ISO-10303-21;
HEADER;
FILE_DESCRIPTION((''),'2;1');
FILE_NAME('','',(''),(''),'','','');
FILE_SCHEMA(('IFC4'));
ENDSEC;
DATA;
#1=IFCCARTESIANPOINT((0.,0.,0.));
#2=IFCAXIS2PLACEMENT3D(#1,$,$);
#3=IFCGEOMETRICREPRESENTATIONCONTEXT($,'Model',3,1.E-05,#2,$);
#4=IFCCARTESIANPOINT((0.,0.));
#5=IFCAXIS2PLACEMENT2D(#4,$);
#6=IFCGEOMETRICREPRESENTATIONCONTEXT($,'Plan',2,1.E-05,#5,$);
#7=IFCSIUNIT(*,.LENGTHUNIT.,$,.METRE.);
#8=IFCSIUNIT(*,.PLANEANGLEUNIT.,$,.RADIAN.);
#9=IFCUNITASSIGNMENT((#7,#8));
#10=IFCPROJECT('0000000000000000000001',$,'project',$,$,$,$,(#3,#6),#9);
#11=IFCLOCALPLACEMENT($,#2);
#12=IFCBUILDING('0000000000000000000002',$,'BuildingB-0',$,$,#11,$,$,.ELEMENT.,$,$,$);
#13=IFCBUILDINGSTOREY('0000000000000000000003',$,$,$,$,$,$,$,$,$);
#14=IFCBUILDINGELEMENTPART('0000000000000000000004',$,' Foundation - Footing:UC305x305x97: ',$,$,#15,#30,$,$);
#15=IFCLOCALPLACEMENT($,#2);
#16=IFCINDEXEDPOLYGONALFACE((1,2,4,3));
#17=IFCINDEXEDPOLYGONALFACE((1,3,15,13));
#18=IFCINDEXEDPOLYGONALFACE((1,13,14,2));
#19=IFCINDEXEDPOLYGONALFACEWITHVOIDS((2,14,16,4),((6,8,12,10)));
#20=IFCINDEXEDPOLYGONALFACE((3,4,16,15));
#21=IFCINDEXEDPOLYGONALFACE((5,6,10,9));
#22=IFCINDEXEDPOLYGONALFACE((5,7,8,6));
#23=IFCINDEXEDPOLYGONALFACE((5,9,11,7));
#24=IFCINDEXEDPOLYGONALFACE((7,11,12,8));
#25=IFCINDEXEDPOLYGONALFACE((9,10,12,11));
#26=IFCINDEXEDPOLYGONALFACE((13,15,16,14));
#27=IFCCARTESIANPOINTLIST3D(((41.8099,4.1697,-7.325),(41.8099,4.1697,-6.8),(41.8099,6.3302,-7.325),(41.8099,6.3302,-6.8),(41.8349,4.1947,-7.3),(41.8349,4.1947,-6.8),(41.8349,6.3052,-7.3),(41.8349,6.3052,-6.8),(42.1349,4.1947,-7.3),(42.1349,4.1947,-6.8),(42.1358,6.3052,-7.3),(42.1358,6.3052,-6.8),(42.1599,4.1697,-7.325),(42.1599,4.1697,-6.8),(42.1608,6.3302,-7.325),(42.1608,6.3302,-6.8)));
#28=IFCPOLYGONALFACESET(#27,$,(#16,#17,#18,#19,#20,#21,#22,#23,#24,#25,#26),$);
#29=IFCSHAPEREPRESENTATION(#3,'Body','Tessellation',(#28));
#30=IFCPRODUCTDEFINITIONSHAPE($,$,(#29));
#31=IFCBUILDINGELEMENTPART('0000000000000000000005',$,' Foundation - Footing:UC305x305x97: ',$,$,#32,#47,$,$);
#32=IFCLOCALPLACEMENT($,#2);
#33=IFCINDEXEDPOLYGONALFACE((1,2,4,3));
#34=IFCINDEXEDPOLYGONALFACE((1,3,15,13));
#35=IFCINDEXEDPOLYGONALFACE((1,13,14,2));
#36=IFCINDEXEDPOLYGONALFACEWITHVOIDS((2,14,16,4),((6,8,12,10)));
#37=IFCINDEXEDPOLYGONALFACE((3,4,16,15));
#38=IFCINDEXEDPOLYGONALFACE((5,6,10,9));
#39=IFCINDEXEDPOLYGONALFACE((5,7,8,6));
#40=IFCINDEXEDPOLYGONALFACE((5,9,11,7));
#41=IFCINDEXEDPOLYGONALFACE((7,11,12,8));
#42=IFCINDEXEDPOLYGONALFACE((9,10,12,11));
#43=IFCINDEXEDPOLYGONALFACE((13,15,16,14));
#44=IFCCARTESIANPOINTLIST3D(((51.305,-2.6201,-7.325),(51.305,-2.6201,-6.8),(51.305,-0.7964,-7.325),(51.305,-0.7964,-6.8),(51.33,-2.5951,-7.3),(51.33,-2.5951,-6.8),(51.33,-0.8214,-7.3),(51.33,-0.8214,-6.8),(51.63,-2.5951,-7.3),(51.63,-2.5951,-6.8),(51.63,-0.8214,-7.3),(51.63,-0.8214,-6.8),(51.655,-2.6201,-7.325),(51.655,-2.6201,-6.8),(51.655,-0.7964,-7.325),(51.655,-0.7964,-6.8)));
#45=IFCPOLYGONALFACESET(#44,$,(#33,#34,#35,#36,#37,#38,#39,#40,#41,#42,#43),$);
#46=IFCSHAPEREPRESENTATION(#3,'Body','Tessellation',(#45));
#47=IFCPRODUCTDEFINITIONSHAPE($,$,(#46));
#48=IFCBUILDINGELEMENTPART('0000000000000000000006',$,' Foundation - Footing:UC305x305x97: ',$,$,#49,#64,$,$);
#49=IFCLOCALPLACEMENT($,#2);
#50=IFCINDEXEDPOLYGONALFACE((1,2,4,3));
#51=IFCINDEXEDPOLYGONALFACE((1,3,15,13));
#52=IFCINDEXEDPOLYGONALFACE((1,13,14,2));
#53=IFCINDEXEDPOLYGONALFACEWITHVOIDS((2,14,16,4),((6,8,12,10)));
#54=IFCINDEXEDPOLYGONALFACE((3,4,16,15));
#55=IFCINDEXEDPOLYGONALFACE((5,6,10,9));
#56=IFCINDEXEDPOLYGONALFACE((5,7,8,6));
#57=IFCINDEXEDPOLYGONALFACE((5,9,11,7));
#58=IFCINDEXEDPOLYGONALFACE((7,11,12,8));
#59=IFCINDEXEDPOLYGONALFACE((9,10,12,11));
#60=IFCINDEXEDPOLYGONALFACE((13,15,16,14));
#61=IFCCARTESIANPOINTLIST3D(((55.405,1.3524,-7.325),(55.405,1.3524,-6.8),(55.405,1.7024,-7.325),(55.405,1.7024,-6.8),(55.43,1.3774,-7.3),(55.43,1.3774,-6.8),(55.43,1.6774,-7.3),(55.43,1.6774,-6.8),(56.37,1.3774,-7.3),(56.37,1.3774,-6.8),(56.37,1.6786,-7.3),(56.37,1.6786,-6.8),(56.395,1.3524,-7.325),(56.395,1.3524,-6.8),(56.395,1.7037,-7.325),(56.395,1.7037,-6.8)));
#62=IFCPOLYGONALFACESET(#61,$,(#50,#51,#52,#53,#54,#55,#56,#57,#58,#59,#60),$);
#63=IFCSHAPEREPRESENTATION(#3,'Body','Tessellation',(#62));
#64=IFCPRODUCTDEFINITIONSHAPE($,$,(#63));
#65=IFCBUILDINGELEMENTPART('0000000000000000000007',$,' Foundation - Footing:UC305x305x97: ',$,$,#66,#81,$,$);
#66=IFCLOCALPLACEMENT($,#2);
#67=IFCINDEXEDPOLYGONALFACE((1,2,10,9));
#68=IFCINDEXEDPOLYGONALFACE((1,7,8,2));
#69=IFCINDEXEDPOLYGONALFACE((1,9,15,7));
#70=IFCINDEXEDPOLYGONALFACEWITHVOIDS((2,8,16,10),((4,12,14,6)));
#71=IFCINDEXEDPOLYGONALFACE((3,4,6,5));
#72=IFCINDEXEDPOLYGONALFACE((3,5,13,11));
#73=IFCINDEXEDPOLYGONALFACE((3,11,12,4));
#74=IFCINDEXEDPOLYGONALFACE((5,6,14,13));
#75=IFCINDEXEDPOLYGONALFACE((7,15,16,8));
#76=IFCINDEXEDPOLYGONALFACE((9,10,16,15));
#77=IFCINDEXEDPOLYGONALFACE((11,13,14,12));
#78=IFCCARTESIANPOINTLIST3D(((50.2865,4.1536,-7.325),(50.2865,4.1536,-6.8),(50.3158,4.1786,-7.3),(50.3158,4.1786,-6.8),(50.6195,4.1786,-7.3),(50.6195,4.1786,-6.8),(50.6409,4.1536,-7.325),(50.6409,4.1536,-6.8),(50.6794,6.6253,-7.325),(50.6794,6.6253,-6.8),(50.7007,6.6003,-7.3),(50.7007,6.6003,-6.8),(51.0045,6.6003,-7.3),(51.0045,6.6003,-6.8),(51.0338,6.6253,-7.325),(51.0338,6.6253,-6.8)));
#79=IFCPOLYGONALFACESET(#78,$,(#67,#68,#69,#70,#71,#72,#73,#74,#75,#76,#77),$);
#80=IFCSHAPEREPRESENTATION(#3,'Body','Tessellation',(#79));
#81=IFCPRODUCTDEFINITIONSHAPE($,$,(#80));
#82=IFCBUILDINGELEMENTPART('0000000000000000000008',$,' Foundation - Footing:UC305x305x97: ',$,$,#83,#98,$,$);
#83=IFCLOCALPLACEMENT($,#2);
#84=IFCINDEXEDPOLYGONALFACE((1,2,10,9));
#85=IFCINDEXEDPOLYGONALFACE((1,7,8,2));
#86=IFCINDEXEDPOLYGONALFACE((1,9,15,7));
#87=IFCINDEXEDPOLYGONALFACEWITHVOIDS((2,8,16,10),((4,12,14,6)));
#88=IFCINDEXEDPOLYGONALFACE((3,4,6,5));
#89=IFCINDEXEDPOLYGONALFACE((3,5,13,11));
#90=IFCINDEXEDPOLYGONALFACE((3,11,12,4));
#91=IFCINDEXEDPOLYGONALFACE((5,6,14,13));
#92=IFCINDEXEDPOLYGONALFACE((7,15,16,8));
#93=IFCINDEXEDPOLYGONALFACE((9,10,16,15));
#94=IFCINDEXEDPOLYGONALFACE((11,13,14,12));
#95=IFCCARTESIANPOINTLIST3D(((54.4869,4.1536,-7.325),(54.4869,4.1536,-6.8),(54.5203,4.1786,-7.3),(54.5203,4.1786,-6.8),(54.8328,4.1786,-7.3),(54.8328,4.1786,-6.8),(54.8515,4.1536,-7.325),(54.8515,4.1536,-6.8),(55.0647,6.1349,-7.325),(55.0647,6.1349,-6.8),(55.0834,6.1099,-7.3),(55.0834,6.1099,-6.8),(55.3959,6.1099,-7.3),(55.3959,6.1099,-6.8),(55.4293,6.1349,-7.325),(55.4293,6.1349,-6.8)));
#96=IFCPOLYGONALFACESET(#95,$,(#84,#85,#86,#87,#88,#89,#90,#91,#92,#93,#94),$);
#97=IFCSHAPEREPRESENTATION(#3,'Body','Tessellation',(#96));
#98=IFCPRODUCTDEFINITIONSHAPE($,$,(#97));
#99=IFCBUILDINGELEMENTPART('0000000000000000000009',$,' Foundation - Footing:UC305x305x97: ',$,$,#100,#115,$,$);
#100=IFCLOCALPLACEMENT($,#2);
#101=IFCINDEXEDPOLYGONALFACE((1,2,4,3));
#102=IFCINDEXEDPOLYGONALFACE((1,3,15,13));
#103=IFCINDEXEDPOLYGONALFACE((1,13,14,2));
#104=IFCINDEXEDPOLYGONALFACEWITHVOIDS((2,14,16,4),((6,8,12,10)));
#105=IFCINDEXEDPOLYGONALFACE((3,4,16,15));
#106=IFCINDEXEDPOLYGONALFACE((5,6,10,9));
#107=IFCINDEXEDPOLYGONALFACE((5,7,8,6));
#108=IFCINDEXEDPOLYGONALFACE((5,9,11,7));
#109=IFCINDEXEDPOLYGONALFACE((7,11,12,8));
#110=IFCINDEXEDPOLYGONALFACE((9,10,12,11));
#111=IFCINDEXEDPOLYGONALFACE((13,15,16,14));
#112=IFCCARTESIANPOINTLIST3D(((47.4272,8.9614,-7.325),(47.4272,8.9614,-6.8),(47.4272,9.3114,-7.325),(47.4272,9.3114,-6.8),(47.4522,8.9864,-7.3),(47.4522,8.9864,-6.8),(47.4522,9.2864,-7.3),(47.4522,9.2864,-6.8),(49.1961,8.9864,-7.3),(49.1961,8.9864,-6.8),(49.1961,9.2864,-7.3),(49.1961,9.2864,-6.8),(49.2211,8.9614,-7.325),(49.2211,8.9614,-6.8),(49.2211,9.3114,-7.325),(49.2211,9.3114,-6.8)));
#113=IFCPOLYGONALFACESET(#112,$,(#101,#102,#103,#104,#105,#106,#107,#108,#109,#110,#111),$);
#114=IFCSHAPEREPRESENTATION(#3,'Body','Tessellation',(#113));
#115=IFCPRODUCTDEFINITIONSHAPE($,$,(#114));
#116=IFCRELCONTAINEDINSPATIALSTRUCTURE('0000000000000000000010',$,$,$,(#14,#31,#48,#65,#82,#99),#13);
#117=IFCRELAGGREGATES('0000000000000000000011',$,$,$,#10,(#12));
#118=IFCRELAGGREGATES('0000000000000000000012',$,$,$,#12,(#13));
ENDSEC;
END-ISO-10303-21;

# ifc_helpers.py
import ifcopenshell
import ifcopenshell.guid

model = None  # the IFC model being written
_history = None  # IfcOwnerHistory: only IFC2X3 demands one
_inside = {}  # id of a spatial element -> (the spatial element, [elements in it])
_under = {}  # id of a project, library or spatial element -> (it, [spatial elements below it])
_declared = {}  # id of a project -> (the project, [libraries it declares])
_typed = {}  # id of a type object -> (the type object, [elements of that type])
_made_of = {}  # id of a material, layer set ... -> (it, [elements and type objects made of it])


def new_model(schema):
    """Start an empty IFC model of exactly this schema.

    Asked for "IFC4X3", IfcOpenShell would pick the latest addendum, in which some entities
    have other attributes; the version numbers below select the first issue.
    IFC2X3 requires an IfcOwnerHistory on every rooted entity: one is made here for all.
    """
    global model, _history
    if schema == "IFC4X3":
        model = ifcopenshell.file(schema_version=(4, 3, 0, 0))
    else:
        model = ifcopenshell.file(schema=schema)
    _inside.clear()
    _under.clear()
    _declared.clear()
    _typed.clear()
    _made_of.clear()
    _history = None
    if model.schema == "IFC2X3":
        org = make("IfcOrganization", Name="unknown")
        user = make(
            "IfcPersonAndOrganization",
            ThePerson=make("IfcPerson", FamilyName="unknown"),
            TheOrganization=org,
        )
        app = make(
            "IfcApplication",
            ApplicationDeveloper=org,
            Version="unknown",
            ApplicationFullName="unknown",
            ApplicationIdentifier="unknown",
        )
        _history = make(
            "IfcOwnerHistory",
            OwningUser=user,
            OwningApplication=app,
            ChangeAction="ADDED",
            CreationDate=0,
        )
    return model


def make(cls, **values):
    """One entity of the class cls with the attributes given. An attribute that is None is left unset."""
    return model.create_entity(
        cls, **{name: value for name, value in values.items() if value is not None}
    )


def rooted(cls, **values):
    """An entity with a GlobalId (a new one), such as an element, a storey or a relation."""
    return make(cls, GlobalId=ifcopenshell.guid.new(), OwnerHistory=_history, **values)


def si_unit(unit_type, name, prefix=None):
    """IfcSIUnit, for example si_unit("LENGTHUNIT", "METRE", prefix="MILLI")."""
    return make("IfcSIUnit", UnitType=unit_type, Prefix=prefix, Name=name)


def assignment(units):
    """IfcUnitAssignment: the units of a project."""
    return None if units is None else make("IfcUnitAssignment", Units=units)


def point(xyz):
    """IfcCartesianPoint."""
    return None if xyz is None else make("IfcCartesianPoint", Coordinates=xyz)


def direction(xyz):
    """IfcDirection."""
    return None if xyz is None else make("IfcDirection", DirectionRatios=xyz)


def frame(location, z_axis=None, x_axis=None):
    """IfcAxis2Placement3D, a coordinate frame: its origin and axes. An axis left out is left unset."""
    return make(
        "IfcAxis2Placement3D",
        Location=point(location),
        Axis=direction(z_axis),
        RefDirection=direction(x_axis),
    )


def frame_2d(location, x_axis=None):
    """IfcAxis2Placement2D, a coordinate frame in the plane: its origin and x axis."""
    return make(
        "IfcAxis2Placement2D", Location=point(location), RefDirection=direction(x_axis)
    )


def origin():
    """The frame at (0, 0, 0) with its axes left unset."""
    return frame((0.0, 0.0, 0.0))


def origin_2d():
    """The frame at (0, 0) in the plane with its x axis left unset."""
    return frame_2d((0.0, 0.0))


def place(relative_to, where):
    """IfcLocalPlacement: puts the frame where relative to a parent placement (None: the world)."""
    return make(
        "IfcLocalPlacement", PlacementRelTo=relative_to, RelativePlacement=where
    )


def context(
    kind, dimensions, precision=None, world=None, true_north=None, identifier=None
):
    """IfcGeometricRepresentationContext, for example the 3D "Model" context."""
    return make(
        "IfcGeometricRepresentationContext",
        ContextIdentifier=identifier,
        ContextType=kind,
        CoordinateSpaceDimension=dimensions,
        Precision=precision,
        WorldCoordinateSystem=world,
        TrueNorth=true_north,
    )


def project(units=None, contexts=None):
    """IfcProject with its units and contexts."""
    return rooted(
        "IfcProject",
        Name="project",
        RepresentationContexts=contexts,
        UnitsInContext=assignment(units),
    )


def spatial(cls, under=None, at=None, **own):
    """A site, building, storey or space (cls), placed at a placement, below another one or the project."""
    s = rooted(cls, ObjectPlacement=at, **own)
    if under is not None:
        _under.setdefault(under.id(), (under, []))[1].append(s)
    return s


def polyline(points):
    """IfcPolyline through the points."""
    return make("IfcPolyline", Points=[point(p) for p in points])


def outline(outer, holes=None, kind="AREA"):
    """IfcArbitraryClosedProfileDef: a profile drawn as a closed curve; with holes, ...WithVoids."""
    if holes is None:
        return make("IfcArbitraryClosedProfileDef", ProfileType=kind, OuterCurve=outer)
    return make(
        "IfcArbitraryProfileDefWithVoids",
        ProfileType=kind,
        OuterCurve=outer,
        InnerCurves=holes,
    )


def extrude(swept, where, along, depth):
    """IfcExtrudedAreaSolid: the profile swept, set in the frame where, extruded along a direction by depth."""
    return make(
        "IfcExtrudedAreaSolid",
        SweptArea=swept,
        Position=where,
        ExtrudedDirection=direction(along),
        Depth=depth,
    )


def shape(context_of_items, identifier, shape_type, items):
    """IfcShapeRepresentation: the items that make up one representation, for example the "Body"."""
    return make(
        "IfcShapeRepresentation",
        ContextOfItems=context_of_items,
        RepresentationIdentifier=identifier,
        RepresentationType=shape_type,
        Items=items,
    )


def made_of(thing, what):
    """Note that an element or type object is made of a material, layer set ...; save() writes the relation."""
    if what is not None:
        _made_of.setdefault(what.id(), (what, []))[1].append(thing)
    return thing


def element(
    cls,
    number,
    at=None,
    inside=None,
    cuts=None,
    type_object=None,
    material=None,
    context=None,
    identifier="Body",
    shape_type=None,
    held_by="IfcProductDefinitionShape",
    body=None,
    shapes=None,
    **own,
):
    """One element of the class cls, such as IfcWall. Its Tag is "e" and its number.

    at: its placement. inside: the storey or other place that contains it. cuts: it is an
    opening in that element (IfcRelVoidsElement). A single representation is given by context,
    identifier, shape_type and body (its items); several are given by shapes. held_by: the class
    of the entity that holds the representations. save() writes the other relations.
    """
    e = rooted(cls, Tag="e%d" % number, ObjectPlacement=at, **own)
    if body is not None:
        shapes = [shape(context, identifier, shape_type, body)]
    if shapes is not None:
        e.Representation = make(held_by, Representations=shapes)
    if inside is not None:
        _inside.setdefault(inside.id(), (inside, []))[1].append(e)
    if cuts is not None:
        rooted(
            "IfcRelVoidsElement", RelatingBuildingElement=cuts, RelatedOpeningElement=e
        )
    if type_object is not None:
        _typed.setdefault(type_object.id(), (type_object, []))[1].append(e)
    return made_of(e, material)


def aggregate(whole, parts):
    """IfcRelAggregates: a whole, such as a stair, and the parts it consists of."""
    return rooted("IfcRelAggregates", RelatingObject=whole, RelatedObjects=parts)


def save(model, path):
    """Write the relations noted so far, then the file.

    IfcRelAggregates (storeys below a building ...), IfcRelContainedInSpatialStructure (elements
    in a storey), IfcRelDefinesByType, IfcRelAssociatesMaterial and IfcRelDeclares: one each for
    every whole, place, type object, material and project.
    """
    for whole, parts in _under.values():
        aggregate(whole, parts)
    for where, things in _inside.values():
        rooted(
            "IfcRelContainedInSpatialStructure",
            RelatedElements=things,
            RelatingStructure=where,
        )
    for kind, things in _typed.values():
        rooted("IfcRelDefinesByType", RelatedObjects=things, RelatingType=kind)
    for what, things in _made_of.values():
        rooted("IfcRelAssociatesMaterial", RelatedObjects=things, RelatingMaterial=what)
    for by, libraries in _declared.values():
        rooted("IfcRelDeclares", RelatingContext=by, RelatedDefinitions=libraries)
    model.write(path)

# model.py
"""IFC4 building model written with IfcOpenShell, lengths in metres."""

from ifc_helpers import new_model, si_unit, origin, origin_2d, place, context, project, spatial, polyline, outline, extrude, element, save


model = new_model("IFC4")

# Units and contexts
model_context = context("Model", 3, precision=1e-05, world=origin())
plan_context = context("Plan", 2, precision=1e-05, world=origin_2d())
ifc_project = project(units=[si_unit("LENGTHUNIT", "METRE"), si_unit("PLANEANGLEUNIT", "RADIAN")], contexts=[model_context, plan_context])

# Building, storey
building_placement = place(None, origin())
building = spatial("IfcBuilding", under=ifc_project, at=building_placement, Name="BuildingB-0", CompositionType="ELEMENT")
storey = spatial("IfcBuildingStorey", under=building)

# Building element parts, openings
building_element_part_1 = element("IfcBuildingElementPart", 1, inside=storey, Name=" Foundation - Footing:UC305x305x97: ", context=model_context, shape_type="SweptSolid", body=[
    extrude(outline(polyline([(41.8099, 4.1697, -7.325), (42.1599, 4.1697, -7.325), (42.1608, 6.3302, -7.325), (41.8099, 6.3302, -7.325), (41.8099, 4.1697, -7.325)])), None, (0.0, 0.0, 1.0), 0.525),
])
element("IfcOpeningElement", 2, inside=storey, cuts=building_element_part_1, context=model_context, shape_type="SweptSolid", body=[
    extrude(outline(polyline([(41.8349, 4.1947, -7.3), (42.1349, 4.1947, -7.3), (42.1358, 6.3052, -7.3), (41.8349, 6.3052, -7.3), (41.8349, 4.1947, -7.3)])), None, (0.0, 0.0, 1.0), 0.5),
])
building_element_part_2 = element("IfcBuildingElementPart", 3, inside=storey, Name=" Foundation - Footing:UC305x305x97: ", context=model_context, shape_type="SweptSolid", body=[
    extrude(outline(polyline([(51.305, -2.6201, -7.325), (51.655, -2.6201, -7.325), (51.655, -0.7964, -7.325), (51.305, -0.7964, -7.325), (51.305, -2.6201, -7.325)])), None, (0.0, 0.0, 1.0), 0.525),
])
element("IfcOpeningElement", 4, inside=storey, cuts=building_element_part_2, context=model_context, shape_type="SweptSolid", body=[
    extrude(outline(polyline([(51.33, -2.5951, -7.3), (51.63, -2.5951, -7.3), (51.63, -0.8214, -7.3), (51.33, -0.8214, -7.3), (51.33, -2.5951, -7.3)])), None, (0.0, 0.0, 1.0), 0.5),
])
building_element_part_3 = element("IfcBuildingElementPart", 5, inside=storey, Name=" Foundation - Footing:UC305x305x97: ", context=model_context, shape_type="SweptSolid", body=[
    extrude(outline(polyline([(55.405, 1.3524, -7.325), (55.405, 1.7024, -7.325), (56.395, 1.7037, -7.325), (56.395, 1.3524, -7.325), (55.405, 1.3524, -7.325)])), None, (0.0, 0.0, 1.0), 0.525),
])
element("IfcOpeningElement", 6, inside=storey, cuts=building_element_part_3, context=model_context, shape_type="SweptSolid", body=[
    extrude(outline(polyline([(55.43, 1.3774, -7.3), (55.43, 1.6774, -7.3), (56.37, 1.6786, -7.3), (56.37, 1.3774, -7.3), (55.43, 1.3774, -7.3)])), None, (0.0, 0.0, 1.0), 0.5),
])
building_element_part_4 = element("IfcBuildingElementPart", 7, inside=storey, Name=" Foundation - Footing:UC305x305x97: ", context=model_context, shape_type="SweptSolid", body=[
    extrude(outline(polyline([(50.2865, 4.1536, -7.325), (50.6794, 6.6253, -7.325), (51.0338, 6.6253, -7.325), (50.6409, 4.1536, -7.325), (50.2865, 4.1536, -7.325)])), None, (0.0, 0.0, 1.0), 0.525),
])
element("IfcOpeningElement", 8, inside=storey, cuts=building_element_part_4, context=model_context, shape_type="SweptSolid", body=[
    extrude(outline(polyline([(50.3158, 4.1786, -7.3), (50.7007, 6.6003, -7.3), (51.0045, 6.6003, -7.3), (50.6195, 4.1786, -7.3), (50.3158, 4.1786, -7.3)])), None, (0.0, 0.0, 1.0), 0.5),
])
building_element_part_5 = element("IfcBuildingElementPart", 9, inside=storey, Name=" Foundation - Footing:UC305x305x97: ", context=model_context, shape_type="SweptSolid", body=[
    extrude(outline(polyline([(54.8515, 4.1536, -7.325), (54.4869, 4.1536, -7.325), (55.0647, 6.1349, -7.325), (55.4293, 6.1349, -7.325), (54.8515, 4.1536, -7.325)])), None, (0.0, 0.0, 1.0), 0.525),
])
element("IfcOpeningElement", 10, inside=storey, cuts=building_element_part_5, context=model_context, shape_type="SweptSolid", body=[
    extrude(outline(polyline([(54.8328, 4.1786, -7.3), (54.5203, 4.1786, -7.3), (55.0834, 6.1099, -7.3), (55.3959, 6.1099, -7.3), (54.8328, 4.1786, -7.3)])), None, (0.0, 0.0, 1.0), 0.5),
])
building_element_part_6 = element("IfcBuildingElementPart", 11, inside=storey, Name=" Foundation - Footing:UC305x305x97: ", context=model_context, shape_type="SweptSolid", body=[
    extrude(outline(polyline([(47.4272, 8.9614, -7.325), (49.2211, 8.9614, -7.325), (49.2211, 9.3114, -7.325), (47.4272, 9.3114, -7.325), (47.4272, 8.9614, -7.325)])), None, (0.0, 0.0, 1.0), 0.525),
])
element("IfcOpeningElement", 12, inside=storey, cuts=building_element_part_6, context=model_context, shape_type="SweptSolid", body=[
    extrude(outline(polyline([(47.4522, 8.9864, -7.3), (49.1961, 8.9864, -7.3), (49.1961, 9.2864, -7.3), (47.4522, 9.2864, -7.3), (47.4522, 8.9864, -7.3)])), None, (0.0, 0.0, 1.0), 0.5),
])

save(model, "model.ifc")
